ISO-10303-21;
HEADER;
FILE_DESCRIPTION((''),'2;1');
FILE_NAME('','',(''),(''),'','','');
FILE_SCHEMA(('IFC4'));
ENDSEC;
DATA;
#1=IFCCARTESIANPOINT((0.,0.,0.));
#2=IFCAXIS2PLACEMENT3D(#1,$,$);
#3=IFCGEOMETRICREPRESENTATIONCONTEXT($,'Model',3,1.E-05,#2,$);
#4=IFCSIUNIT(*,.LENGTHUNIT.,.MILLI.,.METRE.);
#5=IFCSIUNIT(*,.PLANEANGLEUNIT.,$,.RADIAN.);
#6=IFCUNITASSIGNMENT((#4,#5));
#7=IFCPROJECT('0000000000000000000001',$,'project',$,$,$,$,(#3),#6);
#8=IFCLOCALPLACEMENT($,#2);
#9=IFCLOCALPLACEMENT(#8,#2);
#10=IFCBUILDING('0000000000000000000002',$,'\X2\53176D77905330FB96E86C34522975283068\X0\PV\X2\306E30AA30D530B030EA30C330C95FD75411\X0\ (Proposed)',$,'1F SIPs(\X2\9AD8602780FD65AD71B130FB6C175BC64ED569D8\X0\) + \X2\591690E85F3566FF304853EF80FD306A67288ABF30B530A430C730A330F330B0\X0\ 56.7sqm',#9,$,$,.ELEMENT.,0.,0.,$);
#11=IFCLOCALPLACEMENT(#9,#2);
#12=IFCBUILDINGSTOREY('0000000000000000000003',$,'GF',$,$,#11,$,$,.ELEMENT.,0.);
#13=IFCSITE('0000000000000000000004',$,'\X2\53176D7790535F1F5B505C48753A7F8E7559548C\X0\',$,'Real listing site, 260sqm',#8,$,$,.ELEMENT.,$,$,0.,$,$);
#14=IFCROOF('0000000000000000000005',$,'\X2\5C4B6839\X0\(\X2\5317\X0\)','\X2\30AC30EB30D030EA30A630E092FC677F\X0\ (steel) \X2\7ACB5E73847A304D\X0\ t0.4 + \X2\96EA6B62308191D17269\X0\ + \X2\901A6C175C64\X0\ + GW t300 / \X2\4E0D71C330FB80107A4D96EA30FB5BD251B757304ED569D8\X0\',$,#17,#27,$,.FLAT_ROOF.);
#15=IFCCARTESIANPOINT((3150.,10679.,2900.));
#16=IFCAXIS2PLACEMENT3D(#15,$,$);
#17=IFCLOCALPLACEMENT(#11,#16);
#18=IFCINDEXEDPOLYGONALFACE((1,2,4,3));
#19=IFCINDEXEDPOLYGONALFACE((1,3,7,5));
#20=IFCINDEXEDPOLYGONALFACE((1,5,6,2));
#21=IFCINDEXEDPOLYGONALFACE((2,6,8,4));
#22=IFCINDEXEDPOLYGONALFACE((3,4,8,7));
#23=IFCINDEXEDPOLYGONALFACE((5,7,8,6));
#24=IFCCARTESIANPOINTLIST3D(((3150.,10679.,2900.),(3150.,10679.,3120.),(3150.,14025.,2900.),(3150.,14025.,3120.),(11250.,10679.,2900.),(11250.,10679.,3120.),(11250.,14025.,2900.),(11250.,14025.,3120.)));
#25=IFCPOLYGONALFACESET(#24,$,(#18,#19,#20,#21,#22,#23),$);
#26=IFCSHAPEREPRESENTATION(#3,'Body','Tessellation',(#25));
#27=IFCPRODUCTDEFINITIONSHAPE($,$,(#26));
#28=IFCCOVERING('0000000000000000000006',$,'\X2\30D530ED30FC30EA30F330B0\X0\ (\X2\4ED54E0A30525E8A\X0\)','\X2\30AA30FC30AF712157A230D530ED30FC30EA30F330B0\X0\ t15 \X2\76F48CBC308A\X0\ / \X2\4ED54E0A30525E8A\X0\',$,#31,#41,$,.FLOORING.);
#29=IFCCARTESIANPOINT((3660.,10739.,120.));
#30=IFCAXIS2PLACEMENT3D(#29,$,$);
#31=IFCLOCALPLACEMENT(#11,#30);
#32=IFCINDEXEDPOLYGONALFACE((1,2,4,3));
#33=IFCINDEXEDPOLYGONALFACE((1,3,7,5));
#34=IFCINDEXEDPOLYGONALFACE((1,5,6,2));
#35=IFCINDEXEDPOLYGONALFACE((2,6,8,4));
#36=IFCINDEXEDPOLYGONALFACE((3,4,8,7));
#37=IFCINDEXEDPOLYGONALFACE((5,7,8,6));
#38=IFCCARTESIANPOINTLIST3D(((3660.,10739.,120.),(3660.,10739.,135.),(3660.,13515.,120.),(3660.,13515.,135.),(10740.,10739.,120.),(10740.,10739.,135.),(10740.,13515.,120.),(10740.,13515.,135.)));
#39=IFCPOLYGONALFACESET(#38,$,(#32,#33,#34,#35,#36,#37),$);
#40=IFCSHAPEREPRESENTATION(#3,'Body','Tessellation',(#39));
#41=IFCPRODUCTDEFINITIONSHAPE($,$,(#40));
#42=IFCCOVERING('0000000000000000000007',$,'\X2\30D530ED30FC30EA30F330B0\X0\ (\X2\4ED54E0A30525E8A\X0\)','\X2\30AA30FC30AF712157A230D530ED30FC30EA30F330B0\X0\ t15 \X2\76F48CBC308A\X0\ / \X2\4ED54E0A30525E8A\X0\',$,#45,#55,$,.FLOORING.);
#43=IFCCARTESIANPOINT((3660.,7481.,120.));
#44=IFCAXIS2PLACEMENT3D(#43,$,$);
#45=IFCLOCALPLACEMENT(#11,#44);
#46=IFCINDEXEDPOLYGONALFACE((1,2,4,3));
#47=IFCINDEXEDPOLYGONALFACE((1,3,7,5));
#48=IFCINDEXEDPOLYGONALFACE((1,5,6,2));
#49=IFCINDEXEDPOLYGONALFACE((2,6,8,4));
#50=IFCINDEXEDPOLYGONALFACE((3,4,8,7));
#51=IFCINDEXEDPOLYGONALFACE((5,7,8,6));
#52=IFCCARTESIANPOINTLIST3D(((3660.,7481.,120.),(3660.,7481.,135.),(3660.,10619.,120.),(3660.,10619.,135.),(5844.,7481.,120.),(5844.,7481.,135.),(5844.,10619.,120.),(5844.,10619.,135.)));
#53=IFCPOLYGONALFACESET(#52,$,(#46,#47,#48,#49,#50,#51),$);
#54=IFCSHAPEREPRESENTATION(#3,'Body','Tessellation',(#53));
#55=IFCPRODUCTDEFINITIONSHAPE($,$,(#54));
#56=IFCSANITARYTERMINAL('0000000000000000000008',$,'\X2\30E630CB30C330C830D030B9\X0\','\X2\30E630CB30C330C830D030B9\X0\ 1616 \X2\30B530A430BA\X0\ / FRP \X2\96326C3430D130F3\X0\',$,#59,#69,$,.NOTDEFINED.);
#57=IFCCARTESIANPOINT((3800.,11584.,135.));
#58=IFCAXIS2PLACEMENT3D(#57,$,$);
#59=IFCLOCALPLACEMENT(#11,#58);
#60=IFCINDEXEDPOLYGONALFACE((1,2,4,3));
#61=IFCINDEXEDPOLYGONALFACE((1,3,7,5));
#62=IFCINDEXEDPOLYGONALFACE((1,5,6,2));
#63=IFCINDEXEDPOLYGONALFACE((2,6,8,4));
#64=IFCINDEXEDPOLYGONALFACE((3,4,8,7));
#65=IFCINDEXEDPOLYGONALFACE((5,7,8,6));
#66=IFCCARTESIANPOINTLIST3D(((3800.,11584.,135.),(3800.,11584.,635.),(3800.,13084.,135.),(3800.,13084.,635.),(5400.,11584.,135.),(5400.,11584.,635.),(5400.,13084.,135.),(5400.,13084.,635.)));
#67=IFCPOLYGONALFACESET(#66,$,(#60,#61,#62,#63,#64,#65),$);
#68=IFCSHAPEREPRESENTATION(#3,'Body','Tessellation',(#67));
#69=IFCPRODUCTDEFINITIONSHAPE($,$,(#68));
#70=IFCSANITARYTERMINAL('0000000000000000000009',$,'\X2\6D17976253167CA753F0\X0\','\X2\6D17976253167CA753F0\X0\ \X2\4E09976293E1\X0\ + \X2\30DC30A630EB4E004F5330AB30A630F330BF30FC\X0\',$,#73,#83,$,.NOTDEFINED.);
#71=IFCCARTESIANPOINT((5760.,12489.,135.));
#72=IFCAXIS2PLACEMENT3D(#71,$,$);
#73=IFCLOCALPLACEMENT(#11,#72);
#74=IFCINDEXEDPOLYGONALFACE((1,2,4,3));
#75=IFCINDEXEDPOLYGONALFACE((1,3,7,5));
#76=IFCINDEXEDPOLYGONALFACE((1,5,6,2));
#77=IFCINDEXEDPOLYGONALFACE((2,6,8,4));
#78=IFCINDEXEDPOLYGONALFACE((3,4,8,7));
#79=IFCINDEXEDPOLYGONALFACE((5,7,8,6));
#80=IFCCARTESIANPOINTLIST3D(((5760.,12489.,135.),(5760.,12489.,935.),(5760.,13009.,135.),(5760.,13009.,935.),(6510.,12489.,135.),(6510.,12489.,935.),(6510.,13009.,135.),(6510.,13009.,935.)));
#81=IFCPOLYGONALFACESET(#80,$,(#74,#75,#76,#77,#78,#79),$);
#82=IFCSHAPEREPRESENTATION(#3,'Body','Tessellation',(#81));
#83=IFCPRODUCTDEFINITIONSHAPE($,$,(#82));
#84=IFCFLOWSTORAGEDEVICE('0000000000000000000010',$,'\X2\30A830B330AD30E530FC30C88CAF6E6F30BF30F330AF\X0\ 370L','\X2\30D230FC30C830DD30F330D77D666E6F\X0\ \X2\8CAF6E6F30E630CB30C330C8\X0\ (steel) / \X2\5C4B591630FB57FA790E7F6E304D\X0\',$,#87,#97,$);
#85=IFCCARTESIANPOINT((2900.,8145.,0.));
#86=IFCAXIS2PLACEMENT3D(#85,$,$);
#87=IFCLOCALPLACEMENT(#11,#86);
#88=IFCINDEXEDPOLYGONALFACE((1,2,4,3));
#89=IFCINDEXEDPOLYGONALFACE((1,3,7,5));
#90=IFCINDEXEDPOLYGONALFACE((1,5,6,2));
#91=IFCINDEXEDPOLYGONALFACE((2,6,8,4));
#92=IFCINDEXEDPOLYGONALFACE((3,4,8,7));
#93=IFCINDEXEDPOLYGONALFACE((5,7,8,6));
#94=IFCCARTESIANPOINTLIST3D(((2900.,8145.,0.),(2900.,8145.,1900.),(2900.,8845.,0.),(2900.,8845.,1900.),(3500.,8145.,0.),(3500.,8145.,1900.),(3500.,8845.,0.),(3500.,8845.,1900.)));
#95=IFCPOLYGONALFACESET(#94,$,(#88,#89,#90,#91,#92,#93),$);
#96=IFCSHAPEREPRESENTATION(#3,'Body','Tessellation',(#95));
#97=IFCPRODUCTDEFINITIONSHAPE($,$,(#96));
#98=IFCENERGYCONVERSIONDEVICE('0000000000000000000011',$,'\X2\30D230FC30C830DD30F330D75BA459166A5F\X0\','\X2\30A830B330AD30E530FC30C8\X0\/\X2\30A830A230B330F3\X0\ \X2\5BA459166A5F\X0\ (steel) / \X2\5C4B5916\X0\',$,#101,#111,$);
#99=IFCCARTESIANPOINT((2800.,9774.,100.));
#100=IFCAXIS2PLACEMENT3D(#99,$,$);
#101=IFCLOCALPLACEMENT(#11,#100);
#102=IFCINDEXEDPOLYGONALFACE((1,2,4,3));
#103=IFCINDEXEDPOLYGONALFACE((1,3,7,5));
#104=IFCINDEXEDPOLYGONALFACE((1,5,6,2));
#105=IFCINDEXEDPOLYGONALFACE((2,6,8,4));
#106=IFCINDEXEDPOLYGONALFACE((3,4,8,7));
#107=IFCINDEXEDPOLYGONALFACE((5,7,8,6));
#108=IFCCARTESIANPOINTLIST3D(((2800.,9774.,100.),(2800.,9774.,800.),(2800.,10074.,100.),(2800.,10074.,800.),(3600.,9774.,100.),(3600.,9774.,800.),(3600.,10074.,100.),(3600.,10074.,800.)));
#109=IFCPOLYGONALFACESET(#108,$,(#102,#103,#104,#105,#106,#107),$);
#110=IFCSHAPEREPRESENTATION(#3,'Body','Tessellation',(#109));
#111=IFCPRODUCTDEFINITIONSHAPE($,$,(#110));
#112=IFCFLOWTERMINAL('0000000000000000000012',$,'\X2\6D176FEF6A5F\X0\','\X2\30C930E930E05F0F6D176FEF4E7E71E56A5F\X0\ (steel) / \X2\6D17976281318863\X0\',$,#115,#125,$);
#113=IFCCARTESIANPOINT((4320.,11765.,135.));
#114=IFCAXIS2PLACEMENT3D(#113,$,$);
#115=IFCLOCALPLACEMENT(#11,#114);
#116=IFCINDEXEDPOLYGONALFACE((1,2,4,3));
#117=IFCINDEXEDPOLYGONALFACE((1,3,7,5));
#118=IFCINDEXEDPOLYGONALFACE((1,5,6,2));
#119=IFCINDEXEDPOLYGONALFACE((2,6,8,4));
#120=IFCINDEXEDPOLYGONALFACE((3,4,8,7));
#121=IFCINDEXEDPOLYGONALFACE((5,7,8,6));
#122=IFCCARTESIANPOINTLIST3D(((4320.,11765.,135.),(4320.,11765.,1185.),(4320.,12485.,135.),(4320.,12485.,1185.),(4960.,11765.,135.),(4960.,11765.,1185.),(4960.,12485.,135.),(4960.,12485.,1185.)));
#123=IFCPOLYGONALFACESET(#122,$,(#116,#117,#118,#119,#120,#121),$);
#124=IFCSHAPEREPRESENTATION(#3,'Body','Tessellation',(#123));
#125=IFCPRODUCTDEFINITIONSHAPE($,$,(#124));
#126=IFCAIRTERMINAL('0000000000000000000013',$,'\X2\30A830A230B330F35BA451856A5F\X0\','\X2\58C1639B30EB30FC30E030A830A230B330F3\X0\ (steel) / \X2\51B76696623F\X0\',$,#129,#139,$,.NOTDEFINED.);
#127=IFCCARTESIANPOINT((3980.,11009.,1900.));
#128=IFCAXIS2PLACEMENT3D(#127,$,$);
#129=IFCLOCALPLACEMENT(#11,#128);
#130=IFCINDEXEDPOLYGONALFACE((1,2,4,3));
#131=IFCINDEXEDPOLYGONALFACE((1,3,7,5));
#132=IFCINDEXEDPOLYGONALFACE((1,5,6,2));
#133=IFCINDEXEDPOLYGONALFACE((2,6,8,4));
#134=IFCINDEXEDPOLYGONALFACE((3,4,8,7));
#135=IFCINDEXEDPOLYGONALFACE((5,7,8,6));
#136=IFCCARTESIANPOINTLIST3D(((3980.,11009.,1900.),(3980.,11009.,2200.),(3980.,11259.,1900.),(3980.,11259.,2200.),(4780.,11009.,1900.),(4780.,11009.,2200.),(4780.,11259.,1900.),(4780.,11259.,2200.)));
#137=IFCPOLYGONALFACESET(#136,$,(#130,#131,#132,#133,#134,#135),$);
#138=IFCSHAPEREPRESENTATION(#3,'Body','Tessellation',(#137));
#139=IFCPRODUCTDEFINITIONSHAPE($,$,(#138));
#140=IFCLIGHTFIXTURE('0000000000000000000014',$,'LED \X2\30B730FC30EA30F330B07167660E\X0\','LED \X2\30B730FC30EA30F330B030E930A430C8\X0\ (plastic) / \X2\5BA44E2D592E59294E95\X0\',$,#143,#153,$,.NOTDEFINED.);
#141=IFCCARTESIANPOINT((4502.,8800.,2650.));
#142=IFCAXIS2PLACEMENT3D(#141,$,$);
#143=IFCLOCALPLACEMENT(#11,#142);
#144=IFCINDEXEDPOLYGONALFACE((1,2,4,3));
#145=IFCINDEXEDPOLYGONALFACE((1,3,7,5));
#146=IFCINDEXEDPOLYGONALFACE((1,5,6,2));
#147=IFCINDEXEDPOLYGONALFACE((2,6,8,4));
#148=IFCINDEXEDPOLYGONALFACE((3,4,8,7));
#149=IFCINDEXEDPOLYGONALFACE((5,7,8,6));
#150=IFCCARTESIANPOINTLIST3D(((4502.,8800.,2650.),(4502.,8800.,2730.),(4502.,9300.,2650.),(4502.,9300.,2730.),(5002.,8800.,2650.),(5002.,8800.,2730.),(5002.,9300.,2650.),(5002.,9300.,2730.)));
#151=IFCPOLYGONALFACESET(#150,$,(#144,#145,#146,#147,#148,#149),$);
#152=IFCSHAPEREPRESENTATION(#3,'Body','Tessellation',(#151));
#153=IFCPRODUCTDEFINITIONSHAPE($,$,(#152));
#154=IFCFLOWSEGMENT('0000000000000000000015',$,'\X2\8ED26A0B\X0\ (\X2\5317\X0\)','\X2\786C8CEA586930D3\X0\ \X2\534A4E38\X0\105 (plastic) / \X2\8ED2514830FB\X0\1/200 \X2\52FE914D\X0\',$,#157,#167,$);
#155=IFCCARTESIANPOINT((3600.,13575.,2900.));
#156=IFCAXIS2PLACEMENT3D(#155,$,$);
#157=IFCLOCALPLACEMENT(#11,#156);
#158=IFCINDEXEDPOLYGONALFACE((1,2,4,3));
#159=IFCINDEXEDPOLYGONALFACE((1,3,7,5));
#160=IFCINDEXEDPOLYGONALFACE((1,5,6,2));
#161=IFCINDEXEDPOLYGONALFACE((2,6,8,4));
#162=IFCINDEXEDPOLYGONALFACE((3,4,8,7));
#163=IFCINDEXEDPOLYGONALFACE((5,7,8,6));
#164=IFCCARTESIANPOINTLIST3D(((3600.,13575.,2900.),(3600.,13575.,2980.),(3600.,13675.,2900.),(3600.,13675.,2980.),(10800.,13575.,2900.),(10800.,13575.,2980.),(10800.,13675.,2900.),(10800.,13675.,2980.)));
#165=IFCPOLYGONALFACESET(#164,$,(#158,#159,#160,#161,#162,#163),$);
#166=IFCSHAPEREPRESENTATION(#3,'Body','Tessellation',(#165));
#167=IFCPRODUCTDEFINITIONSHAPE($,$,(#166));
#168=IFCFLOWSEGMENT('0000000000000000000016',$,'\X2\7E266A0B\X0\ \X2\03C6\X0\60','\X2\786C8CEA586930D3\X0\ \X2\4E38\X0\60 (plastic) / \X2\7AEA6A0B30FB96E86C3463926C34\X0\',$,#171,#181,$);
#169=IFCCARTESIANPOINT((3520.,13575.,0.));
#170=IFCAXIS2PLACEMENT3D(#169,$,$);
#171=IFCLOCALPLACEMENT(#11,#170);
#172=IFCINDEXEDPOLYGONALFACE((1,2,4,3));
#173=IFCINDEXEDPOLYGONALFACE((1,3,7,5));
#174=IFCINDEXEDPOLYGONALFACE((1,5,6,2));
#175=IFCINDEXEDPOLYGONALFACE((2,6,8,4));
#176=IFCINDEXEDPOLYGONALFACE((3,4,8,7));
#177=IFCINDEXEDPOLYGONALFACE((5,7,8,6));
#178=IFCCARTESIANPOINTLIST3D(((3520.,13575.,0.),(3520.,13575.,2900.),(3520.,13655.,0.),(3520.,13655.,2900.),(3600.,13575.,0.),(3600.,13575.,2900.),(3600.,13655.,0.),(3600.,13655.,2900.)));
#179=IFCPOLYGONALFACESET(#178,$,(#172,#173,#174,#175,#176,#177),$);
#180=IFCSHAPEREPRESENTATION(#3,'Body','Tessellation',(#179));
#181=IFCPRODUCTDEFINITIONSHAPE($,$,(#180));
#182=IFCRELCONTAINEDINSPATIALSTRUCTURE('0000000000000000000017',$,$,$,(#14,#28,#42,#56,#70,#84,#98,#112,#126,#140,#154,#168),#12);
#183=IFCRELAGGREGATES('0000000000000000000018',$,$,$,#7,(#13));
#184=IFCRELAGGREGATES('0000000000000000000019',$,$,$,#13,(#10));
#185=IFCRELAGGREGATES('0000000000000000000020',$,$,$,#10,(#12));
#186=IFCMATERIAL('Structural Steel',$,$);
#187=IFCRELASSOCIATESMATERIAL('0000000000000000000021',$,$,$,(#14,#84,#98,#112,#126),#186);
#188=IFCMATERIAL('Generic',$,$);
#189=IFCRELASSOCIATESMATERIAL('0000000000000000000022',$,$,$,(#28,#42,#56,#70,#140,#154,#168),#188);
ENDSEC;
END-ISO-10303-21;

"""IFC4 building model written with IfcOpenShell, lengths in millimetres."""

from ifc_helpers import new_model, si_unit, frame, frame_2d, origin, place, context, project, spatial, rectangle, extrude, material, element, save


model = new_model("IFC4")

# Units and contexts
model_context = context("Model", 3, precision=1e-05, world=origin())
ifc_project = project(units=[si_unit("LENGTHUNIT", "METRE", prefix="MILLI"), si_unit("PLANEANGLEUNIT", "RADIAN")], contexts=[model_context])

# Site, building, storey
site_placement = place(None, origin())
site = spatial("IfcSite", under=ifc_project, at=site_placement, Name="北海道弟子屈町美留和", ObjectType="Real listing site, 260sqm", CompositionType="ELEMENT", RefElevation=0.0)
building_placement = place(site_placement, origin())
building = spatial("IfcBuilding", under=site, at=building_placement, Name="北海道・雨水利用とPVのオフグリッド志向 (Proposed)", ObjectType="1F SIPs(高性能断熱・気密仕様) + 外部張替え可能な木調サイディング 56.7sqm", CompositionType="ELEMENT", ElevationOfRefHeight=0.0, ElevationOfTerrain=0.0)
storey_placement = place(building_placement, origin())
storey = spatial("IfcBuildingStorey", under=building, at=storey_placement, Name="GF", CompositionType="ELEMENT", Elevation=0.0)

# Roof
ifc_material_1 = material(Name="Structural Steel")
roof_placement = place(storey_placement, frame((3150.0, 10679.0, 2900.0)))
element("IfcRoof", 1, at=roof_placement, inside=storey, material=ifc_material_1, Name="屋根(北)", Description="ガルバリウム鋼板 (steel) 立平葺き t0.4 + 雪止め金物 + 通気層 + GW t300 / 不燃・耐積雪・寒冷地仕様", PredefinedType="FLAT_ROOF", context=model_context, shape_type="SweptSolid", body=[
    extrude(rectangle(XDim=8100.0, YDim=3346.0, at=frame_2d((4050.0, 1673.0))), frame((3150.0, 10679.0, 2900.0)), (0.0, 0.0, 1.0), 220.0),
])

# Coverings
ifc_material_2 = material(Name="Generic")
covering_1_placement = place(storey_placement, frame((3660.0, 10739.0, 120.0)))
element("IfcCovering", 2, at=covering_1_placement, inside=storey, material=ifc_material_2, Name="フローリング (仕上げ床)", Description="オーク無垢フローリング t15 直貼り / 仕上げ床", PredefinedType="FLOORING", context=model_context, shape_type="SweptSolid", body=[
    extrude(rectangle(XDim=7080.0, YDim=2776.0, at=frame_2d((3540.0, 1388.0))), frame((3660.0, 10739.0, 120.0)), (0.0, 0.0, 1.0), 15.0),
])
covering_2_placement = place(storey_placement, frame((3660.0, 7481.0, 120.0)))
element("IfcCovering", 3, at=covering_2_placement, inside=storey, material=ifc_material_2, Name="フローリング (仕上げ床)", Description="オーク無垢フローリング t15 直貼り / 仕上げ床", PredefinedType="FLOORING", context=model_context, shape_type="SweptSolid", body=[
    extrude(rectangle(XDim=2184.0, YDim=3138.0, at=frame_2d((1092.0, 1569.0))), frame((3660.0, 7481.0, 120.0)), (0.0, 0.0, 1.0), 15.0),
])

# Sanitary terminals
sanitary_terminal_1_placement = place(storey_placement, frame((3800.0, 11584.0, 135.0)))
element("IfcSanitaryTerminal", 4, at=sanitary_terminal_1_placement, inside=storey, material=ifc_material_2, Name="ユニットバス", Description="ユニットバス 1616 サイズ / FRP 防水パン", PredefinedType="NOTDEFINED", context=model_context, shape_type="SweptSolid", body=[
    extrude(rectangle(XDim=1600.0, YDim=1500.0, at=frame_2d((800.0, 750.0))), frame((3800.0, 11584.0, 135.0)), (0.0, 0.0, 1.0), 500.0),
])
sanitary_terminal_2_placement = place(storey_placement, frame((5760.0, 12489.0, 135.0)))
element("IfcSanitaryTerminal", 5, at=sanitary_terminal_2_placement, inside=storey, material=ifc_material_2, Name="洗面化粧台", Description="洗面化粧台 三面鏡 + ボウル一体カウンター", PredefinedType="NOTDEFINED", context=model_context, shape_type="SweptSolid", body=[
    extrude(rectangle(XDim=750.0, YDim=520.0, at=frame_2d((375.0, 260.0))), frame((5760.0, 12489.0, 135.0)), (0.0, 0.0, 1.0), 800.0),
])

# Flow storage device
flow_storage_device_placement = place(storey_placement, frame((2900.0, 8145.0, 0.0)))
element("IfcFlowStorageDevice", 6, at=flow_storage_device_placement, inside=storey, material=ifc_material_1, Name="エコキュート貯湯タンク 370L", Description="ヒートポンプ給湯 貯湯ユニット (steel) / 屋外・基礎置き", context=model_context, shape_type="SweptSolid", body=[
    extrude(rectangle(XDim=600.0, YDim=700.0, at=frame_2d((300.0, 350.0))), frame((2900.0, 8145.0, 0.0)), (0.0, 0.0, 1.0), 1900.0),
])

# Energy conversion device
energy_conversion_device_placement = place(storey_placement, frame((2800.0, 9774.0, 100.0)))
element("IfcEnergyConversionDevice", 7, at=energy_conversion_device_placement, inside=storey, material=ifc_material_1, Name="ヒートポンプ室外機", Description="エコキュート/エアコン 室外機 (steel) / 屋外", context=model_context, shape_type="SweptSolid", body=[
    extrude(rectangle(XDim=800.0, YDim=300.0, at=frame_2d((400.0, 150.0))), frame((2800.0, 9774.0, 100.0)), (0.0, 0.0, 1.0), 700.0),
])

# Flow terminal
flow_terminal_placement = place(storey_placement, frame((4320.0, 11765.0, 135.0)))
element("IfcFlowTerminal", 8, at=flow_terminal_placement, inside=storey, material=ifc_material_1, Name="洗濯機", Description="ドラム式洗濯乾燥機 (steel) / 洗面脱衣", context=model_context, shape_type="SweptSolid", body=[
    extrude(rectangle(XDim=640.0, YDim=720.0, at=frame_2d((320.0, 360.0))), frame((4320.0, 11765.0, 135.0)), (0.0, 0.0, 1.0), 1050.0),
])

# Air terminal
air_terminal_placement = place(storey_placement, frame((3980.0, 11009.0, 1900.0)))
element("IfcAirTerminal", 9, at=air_terminal_placement, inside=storey, material=ifc_material_1, Name="エアコン室内機", Description="壁掛ルームエアコン (steel) / 冷暖房", PredefinedType="NOTDEFINED", context=model_context, shape_type="SweptSolid", body=[
    extrude(rectangle(XDim=800.0, YDim=250.0, at=frame_2d((400.0, 125.0))), frame((3980.0, 11009.0, 1900.0)), (0.0, 0.0, 1.0), 300.0),
])

# Light fixture
light_fixture_placement = place(storey_placement, frame((4502.0, 8800.0, 2650.0)))
element("IfcLightFixture", 10, at=light_fixture_placement, inside=storey, material=ifc_material_2, Name="LED シーリング照明", Description="LED シーリングライト (plastic) / 室中央天井", PredefinedType="NOTDEFINED", context=model_context, shape_type="SweptSolid", body=[
    extrude(rectangle(XDim=500.0, YDim=500.0, at=frame_2d((250.0, 250.0))), frame((4502.0, 8800.0, 2650.0)), (0.0, 0.0, 1.0), 80.0),
])

# Flow segments
flow_segment_1_placement = place(storey_placement, frame((3600.0, 13575.0, 2900.0)))
element("IfcFlowSegment", 11, at=flow_segment_1_placement, inside=storey, material=ifc_material_2, Name="軒樋 (北)", Description="硬質塩ビ 半丸105 (plastic) / 軒先・1/200 勾配", context=model_context, shape_type="SweptSolid", body=[
    extrude(rectangle(XDim=7200.0, YDim=100.0, at=frame_2d((3600.0, 50.0))), frame((3600.0, 13575.0, 2900.0)), (0.0, 0.0, 1.0), 80.0),
])
flow_segment_2_placement = place(storey_placement, frame((3520.0, 13575.0, 0.0)))
element("IfcFlowSegment", 12, at=flow_segment_2_placement, inside=storey, material=ifc_material_2, Name="縦樋 φ60", Description="硬質塩ビ 丸60 (plastic) / 竪樋・雨水排水", context=model_context, shape_type="SweptSolid", body=[
    extrude(rectangle(XDim=80.0, YDim=80.0, at=frame_2d((40.0, 40.0))), frame((3520.0, 13575.0, 0.0)), (0.0, 0.0, 1.0), 2900.0),
])

save(model, "model.ifc")
